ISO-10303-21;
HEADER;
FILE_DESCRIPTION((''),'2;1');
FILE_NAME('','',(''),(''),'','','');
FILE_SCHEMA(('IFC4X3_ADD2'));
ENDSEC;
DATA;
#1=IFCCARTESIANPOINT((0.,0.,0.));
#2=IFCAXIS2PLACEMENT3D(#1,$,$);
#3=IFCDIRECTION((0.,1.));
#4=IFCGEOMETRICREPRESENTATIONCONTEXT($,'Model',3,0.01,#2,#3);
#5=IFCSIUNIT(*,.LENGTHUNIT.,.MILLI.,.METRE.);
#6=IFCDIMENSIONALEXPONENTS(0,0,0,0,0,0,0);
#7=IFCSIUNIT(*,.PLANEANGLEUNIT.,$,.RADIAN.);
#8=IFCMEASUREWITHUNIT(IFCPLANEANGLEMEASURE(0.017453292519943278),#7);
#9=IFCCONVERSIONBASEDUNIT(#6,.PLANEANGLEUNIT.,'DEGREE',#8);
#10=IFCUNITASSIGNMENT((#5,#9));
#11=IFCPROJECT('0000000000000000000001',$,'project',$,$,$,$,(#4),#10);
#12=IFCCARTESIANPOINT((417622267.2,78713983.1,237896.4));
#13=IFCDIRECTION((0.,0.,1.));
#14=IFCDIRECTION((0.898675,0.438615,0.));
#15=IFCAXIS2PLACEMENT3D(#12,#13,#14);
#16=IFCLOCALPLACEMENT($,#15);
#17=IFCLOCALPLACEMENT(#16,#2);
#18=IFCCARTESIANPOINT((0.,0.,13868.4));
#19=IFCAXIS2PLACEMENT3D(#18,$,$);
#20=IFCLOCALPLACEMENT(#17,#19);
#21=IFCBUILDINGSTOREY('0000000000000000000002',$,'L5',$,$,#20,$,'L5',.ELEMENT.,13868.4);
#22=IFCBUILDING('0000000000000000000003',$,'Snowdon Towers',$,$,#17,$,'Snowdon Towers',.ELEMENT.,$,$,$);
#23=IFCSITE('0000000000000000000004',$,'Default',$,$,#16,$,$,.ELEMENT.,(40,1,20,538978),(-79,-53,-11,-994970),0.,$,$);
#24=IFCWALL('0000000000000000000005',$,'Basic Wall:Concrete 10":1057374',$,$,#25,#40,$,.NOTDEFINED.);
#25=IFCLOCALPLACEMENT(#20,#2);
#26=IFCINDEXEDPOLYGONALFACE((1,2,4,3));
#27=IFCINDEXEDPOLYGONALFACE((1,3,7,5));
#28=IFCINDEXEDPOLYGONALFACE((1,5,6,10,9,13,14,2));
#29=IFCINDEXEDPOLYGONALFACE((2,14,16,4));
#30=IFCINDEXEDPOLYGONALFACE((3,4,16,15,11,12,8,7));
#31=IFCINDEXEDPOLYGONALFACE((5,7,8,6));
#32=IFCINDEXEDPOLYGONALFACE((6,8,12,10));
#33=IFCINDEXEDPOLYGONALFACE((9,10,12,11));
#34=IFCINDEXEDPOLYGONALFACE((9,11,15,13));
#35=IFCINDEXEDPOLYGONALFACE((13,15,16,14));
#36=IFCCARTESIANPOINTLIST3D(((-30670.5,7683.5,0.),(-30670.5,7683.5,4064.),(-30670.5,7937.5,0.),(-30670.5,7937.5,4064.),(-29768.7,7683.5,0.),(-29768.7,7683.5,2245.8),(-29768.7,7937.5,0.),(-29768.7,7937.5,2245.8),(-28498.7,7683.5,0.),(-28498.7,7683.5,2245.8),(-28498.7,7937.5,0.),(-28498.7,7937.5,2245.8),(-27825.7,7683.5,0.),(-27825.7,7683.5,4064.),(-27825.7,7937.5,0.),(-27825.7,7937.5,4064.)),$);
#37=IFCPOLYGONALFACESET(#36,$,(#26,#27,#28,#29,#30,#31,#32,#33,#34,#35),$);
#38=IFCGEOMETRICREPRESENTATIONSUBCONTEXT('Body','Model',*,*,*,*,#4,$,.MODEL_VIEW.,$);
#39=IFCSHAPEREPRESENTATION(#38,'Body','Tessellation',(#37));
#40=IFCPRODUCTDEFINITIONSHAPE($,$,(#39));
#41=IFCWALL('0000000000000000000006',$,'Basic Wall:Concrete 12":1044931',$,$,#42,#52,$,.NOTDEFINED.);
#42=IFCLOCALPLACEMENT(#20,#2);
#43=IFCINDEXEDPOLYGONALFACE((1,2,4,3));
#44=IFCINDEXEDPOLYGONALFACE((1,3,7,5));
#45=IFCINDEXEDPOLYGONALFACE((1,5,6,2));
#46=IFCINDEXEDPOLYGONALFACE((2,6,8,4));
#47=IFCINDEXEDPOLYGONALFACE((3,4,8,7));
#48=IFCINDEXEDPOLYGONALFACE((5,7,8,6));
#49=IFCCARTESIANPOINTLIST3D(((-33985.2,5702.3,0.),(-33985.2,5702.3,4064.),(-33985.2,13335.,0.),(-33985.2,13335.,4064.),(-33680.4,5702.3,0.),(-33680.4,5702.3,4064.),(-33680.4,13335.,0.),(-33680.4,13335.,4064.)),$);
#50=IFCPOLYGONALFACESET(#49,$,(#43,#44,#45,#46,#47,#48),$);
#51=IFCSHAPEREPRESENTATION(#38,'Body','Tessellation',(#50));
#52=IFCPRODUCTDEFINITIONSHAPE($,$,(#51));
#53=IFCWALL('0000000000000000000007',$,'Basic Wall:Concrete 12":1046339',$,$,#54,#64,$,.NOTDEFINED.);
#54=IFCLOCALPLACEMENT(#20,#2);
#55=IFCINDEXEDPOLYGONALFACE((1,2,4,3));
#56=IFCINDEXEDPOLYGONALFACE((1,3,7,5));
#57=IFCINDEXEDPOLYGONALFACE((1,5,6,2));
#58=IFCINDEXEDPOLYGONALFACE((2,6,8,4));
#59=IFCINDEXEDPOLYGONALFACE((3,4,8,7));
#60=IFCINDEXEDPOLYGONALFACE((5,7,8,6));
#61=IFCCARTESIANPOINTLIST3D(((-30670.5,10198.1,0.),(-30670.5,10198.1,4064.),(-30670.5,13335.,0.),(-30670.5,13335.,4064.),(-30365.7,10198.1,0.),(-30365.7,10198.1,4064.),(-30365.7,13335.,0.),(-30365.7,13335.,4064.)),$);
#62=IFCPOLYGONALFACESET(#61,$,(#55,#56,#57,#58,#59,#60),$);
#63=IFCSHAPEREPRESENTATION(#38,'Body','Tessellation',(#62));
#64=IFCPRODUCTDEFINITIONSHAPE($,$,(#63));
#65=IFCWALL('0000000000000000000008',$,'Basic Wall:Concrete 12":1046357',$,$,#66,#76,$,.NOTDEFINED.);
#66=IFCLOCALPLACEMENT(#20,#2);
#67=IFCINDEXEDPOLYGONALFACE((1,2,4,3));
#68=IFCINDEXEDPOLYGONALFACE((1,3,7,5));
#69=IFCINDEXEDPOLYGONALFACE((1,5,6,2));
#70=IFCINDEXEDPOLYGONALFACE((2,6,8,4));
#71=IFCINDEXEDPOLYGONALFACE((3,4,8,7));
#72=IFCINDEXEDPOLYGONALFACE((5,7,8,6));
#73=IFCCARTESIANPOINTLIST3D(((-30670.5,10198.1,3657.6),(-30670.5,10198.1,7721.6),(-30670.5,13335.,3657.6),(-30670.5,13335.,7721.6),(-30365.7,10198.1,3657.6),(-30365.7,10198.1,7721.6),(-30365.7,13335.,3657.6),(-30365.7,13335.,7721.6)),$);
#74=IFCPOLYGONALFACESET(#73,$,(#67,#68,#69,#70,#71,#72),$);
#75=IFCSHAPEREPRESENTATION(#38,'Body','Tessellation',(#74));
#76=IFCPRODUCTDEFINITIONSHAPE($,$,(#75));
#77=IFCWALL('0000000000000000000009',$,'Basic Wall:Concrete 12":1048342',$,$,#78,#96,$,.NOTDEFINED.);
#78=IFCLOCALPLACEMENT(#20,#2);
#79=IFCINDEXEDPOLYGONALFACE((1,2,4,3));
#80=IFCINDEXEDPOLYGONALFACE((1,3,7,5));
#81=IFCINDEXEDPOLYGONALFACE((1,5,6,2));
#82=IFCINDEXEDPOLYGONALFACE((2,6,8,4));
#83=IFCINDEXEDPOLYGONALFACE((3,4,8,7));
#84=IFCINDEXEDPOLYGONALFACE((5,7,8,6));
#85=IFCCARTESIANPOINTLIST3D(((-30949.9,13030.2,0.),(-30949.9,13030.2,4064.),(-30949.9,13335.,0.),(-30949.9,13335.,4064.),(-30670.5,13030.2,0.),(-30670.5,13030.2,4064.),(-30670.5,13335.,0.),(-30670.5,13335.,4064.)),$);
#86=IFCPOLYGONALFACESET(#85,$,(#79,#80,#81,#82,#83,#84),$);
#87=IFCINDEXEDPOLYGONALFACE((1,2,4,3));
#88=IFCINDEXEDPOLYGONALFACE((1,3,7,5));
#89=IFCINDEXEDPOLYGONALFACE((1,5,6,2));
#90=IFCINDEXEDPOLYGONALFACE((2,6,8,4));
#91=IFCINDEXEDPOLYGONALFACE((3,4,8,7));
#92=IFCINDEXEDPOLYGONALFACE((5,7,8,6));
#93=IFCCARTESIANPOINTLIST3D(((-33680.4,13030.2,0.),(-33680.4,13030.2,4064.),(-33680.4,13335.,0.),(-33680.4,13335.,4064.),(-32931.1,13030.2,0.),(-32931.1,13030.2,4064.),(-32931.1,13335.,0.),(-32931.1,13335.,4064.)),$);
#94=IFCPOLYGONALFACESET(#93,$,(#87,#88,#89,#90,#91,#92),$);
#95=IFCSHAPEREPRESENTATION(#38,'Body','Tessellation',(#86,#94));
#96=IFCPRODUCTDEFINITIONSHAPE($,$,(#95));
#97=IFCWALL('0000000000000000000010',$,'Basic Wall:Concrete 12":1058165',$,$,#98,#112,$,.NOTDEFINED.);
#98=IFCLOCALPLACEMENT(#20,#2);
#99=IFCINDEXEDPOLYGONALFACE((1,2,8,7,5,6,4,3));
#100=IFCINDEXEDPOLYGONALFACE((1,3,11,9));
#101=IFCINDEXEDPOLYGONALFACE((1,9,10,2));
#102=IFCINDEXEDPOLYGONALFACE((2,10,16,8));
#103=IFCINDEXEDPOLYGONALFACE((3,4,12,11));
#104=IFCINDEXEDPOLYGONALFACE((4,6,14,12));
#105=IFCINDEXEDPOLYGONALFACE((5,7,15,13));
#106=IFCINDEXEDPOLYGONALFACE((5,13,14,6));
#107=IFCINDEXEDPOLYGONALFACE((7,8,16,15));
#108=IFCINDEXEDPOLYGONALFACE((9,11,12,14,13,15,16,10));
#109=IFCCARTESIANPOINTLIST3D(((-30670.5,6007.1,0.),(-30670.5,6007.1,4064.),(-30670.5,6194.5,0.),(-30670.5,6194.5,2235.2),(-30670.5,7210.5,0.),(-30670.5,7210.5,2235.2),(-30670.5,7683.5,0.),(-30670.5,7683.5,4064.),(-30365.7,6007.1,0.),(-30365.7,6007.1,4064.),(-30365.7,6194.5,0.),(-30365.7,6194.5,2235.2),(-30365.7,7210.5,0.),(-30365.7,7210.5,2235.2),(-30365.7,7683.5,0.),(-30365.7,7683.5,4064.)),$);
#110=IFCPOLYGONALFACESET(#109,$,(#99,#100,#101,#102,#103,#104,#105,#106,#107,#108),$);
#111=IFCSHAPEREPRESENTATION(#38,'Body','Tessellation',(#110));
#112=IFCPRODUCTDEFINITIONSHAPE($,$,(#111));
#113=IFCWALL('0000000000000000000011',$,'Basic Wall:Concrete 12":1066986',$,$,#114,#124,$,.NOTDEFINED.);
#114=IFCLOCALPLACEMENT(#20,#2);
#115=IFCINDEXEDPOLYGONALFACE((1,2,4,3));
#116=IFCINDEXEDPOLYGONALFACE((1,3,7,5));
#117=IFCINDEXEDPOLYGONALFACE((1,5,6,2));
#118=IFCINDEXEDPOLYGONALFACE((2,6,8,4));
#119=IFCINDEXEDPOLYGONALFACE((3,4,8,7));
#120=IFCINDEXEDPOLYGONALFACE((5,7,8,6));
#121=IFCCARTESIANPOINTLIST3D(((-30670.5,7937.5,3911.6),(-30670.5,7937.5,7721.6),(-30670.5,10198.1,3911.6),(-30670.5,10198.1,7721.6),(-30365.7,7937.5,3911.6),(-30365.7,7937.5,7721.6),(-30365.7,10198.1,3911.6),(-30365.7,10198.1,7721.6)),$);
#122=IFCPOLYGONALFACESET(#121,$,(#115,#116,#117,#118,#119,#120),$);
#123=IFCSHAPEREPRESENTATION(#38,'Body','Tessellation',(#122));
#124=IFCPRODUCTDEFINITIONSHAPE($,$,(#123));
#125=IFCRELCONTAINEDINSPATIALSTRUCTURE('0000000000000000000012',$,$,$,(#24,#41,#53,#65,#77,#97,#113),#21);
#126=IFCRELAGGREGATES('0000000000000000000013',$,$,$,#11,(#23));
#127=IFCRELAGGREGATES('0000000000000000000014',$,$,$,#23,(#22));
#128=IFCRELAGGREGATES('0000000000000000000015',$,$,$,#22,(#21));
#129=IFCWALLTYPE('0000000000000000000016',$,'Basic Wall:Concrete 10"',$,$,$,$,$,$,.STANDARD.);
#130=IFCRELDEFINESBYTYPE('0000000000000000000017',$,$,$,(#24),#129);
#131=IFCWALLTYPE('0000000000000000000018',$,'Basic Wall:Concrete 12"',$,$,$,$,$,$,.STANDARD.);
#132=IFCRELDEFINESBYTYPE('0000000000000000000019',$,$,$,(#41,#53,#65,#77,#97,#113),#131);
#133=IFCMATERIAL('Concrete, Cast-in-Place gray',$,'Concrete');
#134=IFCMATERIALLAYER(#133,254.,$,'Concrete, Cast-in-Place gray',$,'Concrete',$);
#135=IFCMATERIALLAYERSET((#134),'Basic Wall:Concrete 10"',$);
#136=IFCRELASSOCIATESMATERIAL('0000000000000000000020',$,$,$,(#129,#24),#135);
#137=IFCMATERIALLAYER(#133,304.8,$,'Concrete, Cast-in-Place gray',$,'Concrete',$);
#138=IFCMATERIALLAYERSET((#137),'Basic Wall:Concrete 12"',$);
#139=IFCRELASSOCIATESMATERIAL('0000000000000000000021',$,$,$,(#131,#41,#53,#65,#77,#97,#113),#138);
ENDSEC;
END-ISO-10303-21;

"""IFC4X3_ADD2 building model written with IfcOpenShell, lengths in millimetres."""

from ifc_helpers import new_model, entity, si_unit, converted_unit, direction, frame, frame_2d, origin, place, context, subcontext, project, spatial, rectangle, extrude, material, layer, layer_set, type_object, element, save


model = new_model("IFC4X3_ADD2")

# Units and contexts
model_context = context("Model", 3, precision=0.01, world=origin(), true_north=direction((0.0, 1.0)))
body_context = subcontext(model_context, "Body", "Model", "MODEL_VIEW")
ifc_project = project(units=[si_unit("LENGTHUNIT", "METRE", prefix="MILLI"), converted_unit("PLANEANGLEUNIT", "DEGREE", entity("IfcPlaneAngleMeasure", 0.017453292519943278), si_unit("PLANEANGLEUNIT", "RADIAN"), dimensions=[0, 0, 0, 0, 0, 0, 0])], contexts=[model_context])

# Site, building, storey
site_placement = place(None, frame((417622267.2, 78713983.1, 237896.4), z_axis=(0.0, 0.0, 1.0), x_axis=(0.898675, 0.438615, 0.0)))
site = spatial("IfcSite", under=ifc_project, at=site_placement, Name="Default", CompositionType="ELEMENT", RefLatitude=(40, 1, 20, 538978), RefLongitude=(-79, -53, -11, -994970), RefElevation=0.0)
building_placement = place(site_placement, origin())
building = spatial("IfcBuilding", under=site, at=building_placement, Name="Snowdon Towers", LongName="Snowdon Towers", CompositionType="ELEMENT")
storey_placement = place(building_placement, frame((0.0, 0.0, 13868.4)))
storey = spatial("IfcBuildingStorey", under=building, at=storey_placement, Name="L5", LongName="L5", CompositionType="ELEMENT", Elevation=13868.4)

# Shared definitions
ifc_material_1 = material(Name="Concrete, Cast-in-Place gray", Category="Concrete")
ifc_layer_1 = layer(ifc_material_1, 254.0, Name="Concrete, Cast-in-Place gray", Category="Concrete")
ifc_layer_set_1 = layer_set([ifc_layer_1], Name="Basic Wall:Concrete 10\"")
wall_type_1 = type_object("IfcWallType", Name="Basic Wall:Concrete 10\"", PredefinedType="STANDARD", material=ifc_layer_set_1)

# Wall, opening
wall_1_placement = place(storey_placement, frame((-27825.7, 7810.5, 0.0), z_axis=(0.0, 0.0, 1.0), x_axis=(-1.0, 0.0, 0.0)))
wall_1 = element("IfcWall", 1, at=wall_1_placement, inside=storey, type_object=wall_type_1, material=ifc_layer_set_1, Name="Basic Wall:Concrete 10\":1057374", PredefinedType="NOTDEFINED", context=body_context, shape_type="SweptSolid", body=[
    extrude(rectangle(XDim=2844.8, YDim=254.0, at=frame_2d((1422.4, 0.0), x_axis=(-1.0, 0.0))), origin(), (0.0, 0.0, 1.0), 4064.0),
])
opening_1_placement = place(wall_1_placement, origin())
element("IfcOpeningElement", 2, at=opening_1_placement, cuts=wall_1, PredefinedType="OPENING", context=body_context, shape_type="SweptSolid", body=[
    extrude(rectangle(XDim=2245.8, YDim=1270.0, at=frame_2d((0.0, 0.0), x_axis=(0.0, 1.0))), frame((1308.0, 127.0, 1122.9), z_axis=(0.0, -1.0, 0.0), x_axis=(1.0, 0.0, 0.0)), (0.0, 0.0, 1.0), 254.0),
])

# Walls
ifc_layer_2 = layer(ifc_material_1, 304.8, Name="Concrete, Cast-in-Place gray", Category="Concrete")
ifc_layer_set_2 = layer_set([ifc_layer_2], Name="Basic Wall:Concrete 12\"")
wall_type_2 = type_object("IfcWallType", Name="Basic Wall:Concrete 12\"", PredefinedType="STANDARD", material=ifc_layer_set_2)
wall_2_placement = place(storey_placement, frame((-33832.8, 13335.0, 0.0), z_axis=(0.0, 0.0, 1.0), x_axis=(0.0, -1.0, 0.0)))
element("IfcWall", 3, at=wall_2_placement, inside=storey, type_object=wall_type_2, material=ifc_layer_set_2, Name="Basic Wall:Concrete 12\":1044931", PredefinedType="NOTDEFINED", context=body_context, shape_type="SweptSolid", body=[
    extrude(rectangle(XDim=7632.7, YDim=304.8, at=frame_2d((3816.4, 0.0), x_axis=(-1.0, 0.0))), origin(), (0.0, 0.0, 1.0), 4064.0),
])
wall_3_placement = place(storey_placement, frame((-30518.1, 10198.1, 0.0), z_axis=(0.0, 0.0, 1.0), x_axis=(0.0, 1.0, 0.0)))
element("IfcWall", 4, at=wall_3_placement, inside=storey, type_object=wall_type_2, material=ifc_layer_set_2, Name="Basic Wall:Concrete 12\":1046339", PredefinedType="NOTDEFINED", context=body_context, shape_type="SweptSolid", body=[
    extrude(rectangle(XDim=3136.9, YDim=304.8, at=frame_2d((1568.5, 0.0), x_axis=(-1.0, 0.0))), origin(), (0.0, 0.0, 1.0), 4064.0),
])
wall_4_placement = place(storey_placement, frame((-30518.1, 10198.1, 3657.6), z_axis=(0.0, 0.0, 1.0), x_axis=(0.0, 1.0, 0.0)))
element("IfcWall", 5, at=wall_4_placement, inside=storey, type_object=wall_type_2, material=ifc_layer_set_2, Name="Basic Wall:Concrete 12\":1046357", PredefinedType="NOTDEFINED", context=body_context, shape_type="SweptSolid", body=[
    extrude(rectangle(XDim=3136.9, YDim=304.8, at=frame_2d((1568.5, 0.0), x_axis=(-1.0, 0.0))), origin(), (0.0, 0.0, 1.0), 4064.0),
])
wall_5_placement = place(storey_placement, frame((-30670.5, 13182.6, 0.0), z_axis=(0.0, 0.0, 1.0), x_axis=(-1.0, 0.0, 0.0)))
element("IfcWall", 6, at=wall_5_placement, inside=storey, type_object=wall_type_2, material=ifc_layer_set_2, Name="Basic Wall:Concrete 12\":1048342", PredefinedType="NOTDEFINED", context=body_context, shape_type="SweptSolid", body=[
    extrude(rectangle(XDim=304.8, YDim=279.4, at=frame_2d((0.0, 0.0), x_axis=(1.0, 0.0))), frame((139.7, 0.0, 0.0), z_axis=(0.0, 0.0, 1.0), x_axis=(0.0, 1.0, 0.0)), (0.0, 0.0, 1.0), 4064.0),
    extrude(rectangle(XDim=304.8, YDim=749.3, at=frame_2d((0.0, 0.0), x_axis=(1.0, 0.0))), frame((2635.3, 0.0, 0.0), z_axis=(0.0, 0.0, 1.0), x_axis=(0.0, 1.0, 0.0)), (0.0, 0.0, 1.0), 4064.0),
])

# Wall, opening
wall_6_placement = place(storey_placement, frame((-30518.1, 7683.5, 0.0), z_axis=(0.0, 0.0, 1.0), x_axis=(0.0, -1.0, 0.0)))
wall_6 = element("IfcWall", 7, at=wall_6_placement, inside=storey, type_object=wall_type_2, material=ifc_layer_set_2, Name="Basic Wall:Concrete 12\":1058165", PredefinedType="NOTDEFINED", context=body_context, shape_type="SweptSolid", body=[
    extrude(rectangle(XDim=1676.4, YDim=304.8, at=frame_2d((838.2, 0.0), x_axis=(-1.0, 0.0))), origin(), (0.0, 0.0, 1.0), 4064.0),
])
opening_2_placement = place(wall_6_placement, origin())
element("IfcOpeningElement", 8, at=opening_2_placement, cuts=wall_6, PredefinedType="OPENING", context=body_context, shape_type="SweptSolid", body=[
    extrude(rectangle(XDim=2235.2, YDim=1016.0, at=frame_2d((0.0, 0.0), x_axis=(0.0, 1.0))), frame((981.0, 152.4, 1117.6), z_axis=(0.0, -1.0, 0.0), x_axis=(1.0, 0.0, 0.0)), (0.0, 0.0, 1.0), 304.8),
])

# Wall
wall_7_placement = place(storey_placement, frame((-30518.1, 7937.5, 3911.6), z_axis=(0.0, 0.0, 1.0), x_axis=(0.0, 1.0, 0.0)))
element("IfcWall", 9, at=wall_7_placement, inside=storey, type_object=wall_type_2, material=ifc_layer_set_2, Name="Basic Wall:Concrete 12\":1066986", PredefinedType="NOTDEFINED", context=body_context, shape_type="SweptSolid", body=[
    extrude(rectangle(XDim=2260.6, YDim=304.8, at=frame_2d((1130.3, 0.0), x_axis=(-1.0, 0.0))), origin(), (0.0, 0.0, 1.0), 3810.0),
])

save(model, "model.ifc")
